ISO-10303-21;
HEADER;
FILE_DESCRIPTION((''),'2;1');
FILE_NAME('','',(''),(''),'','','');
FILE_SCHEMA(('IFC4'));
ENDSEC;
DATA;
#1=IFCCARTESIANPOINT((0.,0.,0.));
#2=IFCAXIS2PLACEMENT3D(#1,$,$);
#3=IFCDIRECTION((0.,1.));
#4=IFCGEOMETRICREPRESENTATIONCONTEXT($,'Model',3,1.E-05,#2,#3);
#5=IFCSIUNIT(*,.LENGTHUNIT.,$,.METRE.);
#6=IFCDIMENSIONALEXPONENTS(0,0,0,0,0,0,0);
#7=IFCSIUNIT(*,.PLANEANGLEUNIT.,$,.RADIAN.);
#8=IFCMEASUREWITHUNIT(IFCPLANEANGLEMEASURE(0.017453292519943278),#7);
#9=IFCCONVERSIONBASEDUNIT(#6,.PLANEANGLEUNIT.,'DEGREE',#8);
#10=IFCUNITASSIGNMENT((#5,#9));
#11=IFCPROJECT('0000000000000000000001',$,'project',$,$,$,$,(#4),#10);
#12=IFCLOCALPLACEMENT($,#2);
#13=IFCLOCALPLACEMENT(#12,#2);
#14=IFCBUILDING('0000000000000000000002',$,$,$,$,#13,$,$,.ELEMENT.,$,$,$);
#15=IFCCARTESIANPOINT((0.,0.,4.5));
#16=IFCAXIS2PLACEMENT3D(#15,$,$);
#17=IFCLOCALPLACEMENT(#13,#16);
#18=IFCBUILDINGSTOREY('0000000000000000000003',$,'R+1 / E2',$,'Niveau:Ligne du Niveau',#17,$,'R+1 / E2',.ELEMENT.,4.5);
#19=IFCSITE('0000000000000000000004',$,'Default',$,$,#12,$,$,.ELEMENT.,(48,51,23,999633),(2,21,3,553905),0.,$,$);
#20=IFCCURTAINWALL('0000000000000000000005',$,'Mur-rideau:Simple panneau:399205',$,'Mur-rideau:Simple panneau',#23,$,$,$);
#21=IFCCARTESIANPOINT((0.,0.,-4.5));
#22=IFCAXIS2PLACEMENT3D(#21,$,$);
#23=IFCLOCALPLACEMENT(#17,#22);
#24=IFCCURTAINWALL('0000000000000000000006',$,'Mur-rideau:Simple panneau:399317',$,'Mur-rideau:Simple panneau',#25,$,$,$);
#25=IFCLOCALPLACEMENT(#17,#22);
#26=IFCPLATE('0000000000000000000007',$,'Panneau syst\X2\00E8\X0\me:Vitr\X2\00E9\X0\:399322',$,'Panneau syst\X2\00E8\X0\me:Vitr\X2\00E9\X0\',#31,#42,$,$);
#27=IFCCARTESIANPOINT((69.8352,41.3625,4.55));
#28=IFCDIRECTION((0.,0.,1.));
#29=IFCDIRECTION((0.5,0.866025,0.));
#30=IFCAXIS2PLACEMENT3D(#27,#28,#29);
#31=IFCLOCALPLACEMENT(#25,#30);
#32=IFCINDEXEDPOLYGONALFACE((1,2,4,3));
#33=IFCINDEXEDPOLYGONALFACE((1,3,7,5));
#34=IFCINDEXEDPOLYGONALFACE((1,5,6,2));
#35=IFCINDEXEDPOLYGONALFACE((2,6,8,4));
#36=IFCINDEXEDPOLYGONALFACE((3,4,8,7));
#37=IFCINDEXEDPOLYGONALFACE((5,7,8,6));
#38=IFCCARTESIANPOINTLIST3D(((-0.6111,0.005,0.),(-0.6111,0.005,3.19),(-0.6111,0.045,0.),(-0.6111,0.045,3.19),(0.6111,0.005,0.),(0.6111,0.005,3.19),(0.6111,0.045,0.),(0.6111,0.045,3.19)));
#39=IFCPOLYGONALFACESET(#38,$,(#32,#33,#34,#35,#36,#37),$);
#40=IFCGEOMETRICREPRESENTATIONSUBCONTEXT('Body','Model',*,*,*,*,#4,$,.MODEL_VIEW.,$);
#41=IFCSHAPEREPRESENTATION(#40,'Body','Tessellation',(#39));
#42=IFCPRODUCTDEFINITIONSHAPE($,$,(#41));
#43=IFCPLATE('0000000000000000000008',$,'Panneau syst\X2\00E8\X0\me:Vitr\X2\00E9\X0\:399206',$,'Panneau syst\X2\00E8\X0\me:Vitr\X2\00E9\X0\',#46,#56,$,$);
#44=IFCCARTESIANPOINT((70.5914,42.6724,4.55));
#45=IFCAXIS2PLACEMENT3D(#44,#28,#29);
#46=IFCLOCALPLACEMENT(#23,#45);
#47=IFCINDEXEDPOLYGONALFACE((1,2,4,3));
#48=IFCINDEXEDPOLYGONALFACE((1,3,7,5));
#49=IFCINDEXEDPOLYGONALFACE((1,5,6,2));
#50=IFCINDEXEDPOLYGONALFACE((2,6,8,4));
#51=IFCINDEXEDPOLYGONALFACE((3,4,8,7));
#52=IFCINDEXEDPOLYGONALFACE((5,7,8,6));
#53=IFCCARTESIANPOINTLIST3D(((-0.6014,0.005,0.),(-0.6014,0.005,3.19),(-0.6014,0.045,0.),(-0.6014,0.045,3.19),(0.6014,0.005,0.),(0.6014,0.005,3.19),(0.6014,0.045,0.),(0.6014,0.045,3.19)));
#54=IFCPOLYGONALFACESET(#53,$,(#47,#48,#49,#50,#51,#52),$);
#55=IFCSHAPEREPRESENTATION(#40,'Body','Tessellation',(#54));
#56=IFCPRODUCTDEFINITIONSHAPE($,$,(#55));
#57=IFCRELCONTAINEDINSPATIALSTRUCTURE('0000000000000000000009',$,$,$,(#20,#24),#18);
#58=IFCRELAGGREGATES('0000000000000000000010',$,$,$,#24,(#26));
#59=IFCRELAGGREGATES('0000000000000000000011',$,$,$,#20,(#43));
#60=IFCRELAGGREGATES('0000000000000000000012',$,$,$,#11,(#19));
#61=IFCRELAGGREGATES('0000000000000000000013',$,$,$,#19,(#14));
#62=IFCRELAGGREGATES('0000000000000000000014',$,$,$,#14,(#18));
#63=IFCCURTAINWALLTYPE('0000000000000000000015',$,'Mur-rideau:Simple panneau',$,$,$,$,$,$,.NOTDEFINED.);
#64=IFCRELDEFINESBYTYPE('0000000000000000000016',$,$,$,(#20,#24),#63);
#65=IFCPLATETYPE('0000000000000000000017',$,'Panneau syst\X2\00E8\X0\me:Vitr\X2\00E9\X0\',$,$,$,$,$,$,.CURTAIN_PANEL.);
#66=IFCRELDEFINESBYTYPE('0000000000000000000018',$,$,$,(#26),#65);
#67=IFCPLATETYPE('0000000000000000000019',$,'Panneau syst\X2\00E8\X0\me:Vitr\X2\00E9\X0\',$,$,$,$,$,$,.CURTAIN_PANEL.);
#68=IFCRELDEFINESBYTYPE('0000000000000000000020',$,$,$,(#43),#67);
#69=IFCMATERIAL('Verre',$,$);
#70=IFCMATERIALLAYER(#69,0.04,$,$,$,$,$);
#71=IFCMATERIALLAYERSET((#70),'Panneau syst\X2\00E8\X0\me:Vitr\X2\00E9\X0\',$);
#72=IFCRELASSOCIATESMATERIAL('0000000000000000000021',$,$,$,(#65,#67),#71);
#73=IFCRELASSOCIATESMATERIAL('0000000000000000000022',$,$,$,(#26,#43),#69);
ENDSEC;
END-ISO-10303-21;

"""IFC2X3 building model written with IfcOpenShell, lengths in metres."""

from ifc_helpers import new_model, entity, si_unit, converted_unit, direction, frame, frame_2d, origin, place, context, subcontext, project, spatial, rectangle, extrude, source, transform, mapped, material, layer, layer_set, type_object, type_shapes, element, aggregate, save


model = new_model("IFC2X3")

# Units and contexts
model_context = context("Model", 3, precision=1e-05, world=origin(), true_north=direction((0.0, 1.0)))
body_context = subcontext(model_context, "Body", "Model", "MODEL_VIEW")
ifc_project = project(units=[si_unit("LENGTHUNIT", "METRE"), converted_unit("PLANEANGLEUNIT", "DEGREE", entity("IfcPlaneAngleMeasure", 0.017453292519943278), si_unit("PLANEANGLEUNIT", "RADIAN"), dimensions=[0, 0, 0, 0, 0, 0, 0])], contexts=[model_context])

# Site, building, storey
site_placement = place(None, origin())
site = spatial("IfcSite", under=ifc_project, at=site_placement, Name="Default", CompositionType="ELEMENT", RefLatitude=(48, 51, 23, 999633), RefLongitude=(2, 21, 3, 553905), RefElevation=0.0)
building_placement = place(site_placement, origin())
building = spatial("IfcBuilding", under=site, at=building_placement, CompositionType="ELEMENT")
storey_placement = place(building_placement, frame((0.0, 0.0, 4.5)))
storey = spatial("IfcBuildingStorey", under=building, at=storey_placement, Name="R+1 / E2", ObjectType="Niveau:Ligne du Niveau", LongName="R+1 / E2", CompositionType="ELEMENT", Elevation=4.5)

# Curtain walls
curtain_wall_type = type_object("IfcCurtainWallType", Name="Mur-rideau:Simple panneau", PredefinedType="NOTDEFINED")
curtain_wall_1_placement = place(storey_placement, frame((0.0, 0.0, -4.5)))
curtain_wall_1 = element("IfcCurtainWall", 1, at=curtain_wall_1_placement, inside=storey, type_object=curtain_wall_type, Name="Mur-rideau:Simple panneau:399205", ObjectType="Mur-rideau:Simple panneau")
curtain_wall_2_placement = place(storey_placement, frame((0.0, 0.0, -4.5)))
curtain_wall_2 = element("IfcCurtainWall", 2, at=curtain_wall_2_placement, inside=storey, type_object=curtain_wall_type, Name="Mur-rideau:Simple panneau:399317", ObjectType="Mur-rideau:Simple panneau")

# Plates
ifc_material_1 = material(Name="Verre")
ifc_layer_1 = layer(ifc_material_1, 0.04)
ifc_layer_set_1 = layer_set([ifc_layer_1], Name="Panneau système:Vitré")
plate_type_1 = type_object("IfcPlateType", Name="Panneau système:Vitré", PredefinedType="CURTAIN_PANEL", material=ifc_layer_set_1)
shared_shape_1 = source(origin(), body_context, "Body", "SweptSolid", [
    extrude(rectangle(XDim=0.04, YDim=1.2221, at=frame_2d((0.0, 0.0), x_axis=(1.0, 0.0))), frame((0.0, 0.025, 0.0), z_axis=(0.0, 0.0, 1.0), x_axis=(0.0, 1.0, 0.0)), (0.0, 0.0, 1.0), 3.19),
])
type_shapes(plate_type_1, [shared_shape_1])
plate_1_placement = place(curtain_wall_2_placement, frame((69.8352, 41.3625, 4.55), z_axis=(0.0, 0.0, 1.0), x_axis=(0.5, 0.866025, 0.0)))
plate_1 = element("IfcPlate", 3, at=plate_1_placement, type_object=plate_type_1, material=ifc_material_1, Name="Panneau système:Vitré:399322", ObjectType="Panneau système:Vitré", context=body_context, shape_type="MappedRepresentation", body=[
    mapped(shared_shape_1, transform((0.0, 0.0, 0.0), scale=1.0)),
])
aggregate(curtain_wall_2, [plate_1])
plate_type_2 = type_object("IfcPlateType", Name="Panneau système:Vitré", PredefinedType="CURTAIN_PANEL", material=ifc_layer_set_1)
shared_shape_2 = source(origin(), body_context, "Body", "SweptSolid", [
    extrude(rectangle(XDim=0.04, YDim=1.2029, at=frame_2d((0.0, 0.0), x_axis=(1.0, 0.0))), frame((0.0, 0.025, 0.0), z_axis=(0.0, 0.0, 1.0), x_axis=(0.0, 1.0, 0.0)), (0.0, 0.0, 1.0), 3.19),
])
type_shapes(plate_type_2, [shared_shape_2])
plate_2_placement = place(curtain_wall_1_placement, frame((70.5914, 42.6724, 4.55), z_axis=(0.0, 0.0, 1.0), x_axis=(0.5, 0.866025, 0.0)))
plate_2 = element("IfcPlate", 4, at=plate_2_placement, type_object=plate_type_2, material=ifc_material_1, Name="Panneau système:Vitré:399206", ObjectType="Panneau système:Vitré", context=body_context, shape_type="MappedRepresentation", body=[
    mapped(shared_shape_2, transform((0.0, 0.0, 0.0), scale=1.0)),
])
aggregate(curtain_wall_1, [plate_2])

save(model, "model.ifc")
